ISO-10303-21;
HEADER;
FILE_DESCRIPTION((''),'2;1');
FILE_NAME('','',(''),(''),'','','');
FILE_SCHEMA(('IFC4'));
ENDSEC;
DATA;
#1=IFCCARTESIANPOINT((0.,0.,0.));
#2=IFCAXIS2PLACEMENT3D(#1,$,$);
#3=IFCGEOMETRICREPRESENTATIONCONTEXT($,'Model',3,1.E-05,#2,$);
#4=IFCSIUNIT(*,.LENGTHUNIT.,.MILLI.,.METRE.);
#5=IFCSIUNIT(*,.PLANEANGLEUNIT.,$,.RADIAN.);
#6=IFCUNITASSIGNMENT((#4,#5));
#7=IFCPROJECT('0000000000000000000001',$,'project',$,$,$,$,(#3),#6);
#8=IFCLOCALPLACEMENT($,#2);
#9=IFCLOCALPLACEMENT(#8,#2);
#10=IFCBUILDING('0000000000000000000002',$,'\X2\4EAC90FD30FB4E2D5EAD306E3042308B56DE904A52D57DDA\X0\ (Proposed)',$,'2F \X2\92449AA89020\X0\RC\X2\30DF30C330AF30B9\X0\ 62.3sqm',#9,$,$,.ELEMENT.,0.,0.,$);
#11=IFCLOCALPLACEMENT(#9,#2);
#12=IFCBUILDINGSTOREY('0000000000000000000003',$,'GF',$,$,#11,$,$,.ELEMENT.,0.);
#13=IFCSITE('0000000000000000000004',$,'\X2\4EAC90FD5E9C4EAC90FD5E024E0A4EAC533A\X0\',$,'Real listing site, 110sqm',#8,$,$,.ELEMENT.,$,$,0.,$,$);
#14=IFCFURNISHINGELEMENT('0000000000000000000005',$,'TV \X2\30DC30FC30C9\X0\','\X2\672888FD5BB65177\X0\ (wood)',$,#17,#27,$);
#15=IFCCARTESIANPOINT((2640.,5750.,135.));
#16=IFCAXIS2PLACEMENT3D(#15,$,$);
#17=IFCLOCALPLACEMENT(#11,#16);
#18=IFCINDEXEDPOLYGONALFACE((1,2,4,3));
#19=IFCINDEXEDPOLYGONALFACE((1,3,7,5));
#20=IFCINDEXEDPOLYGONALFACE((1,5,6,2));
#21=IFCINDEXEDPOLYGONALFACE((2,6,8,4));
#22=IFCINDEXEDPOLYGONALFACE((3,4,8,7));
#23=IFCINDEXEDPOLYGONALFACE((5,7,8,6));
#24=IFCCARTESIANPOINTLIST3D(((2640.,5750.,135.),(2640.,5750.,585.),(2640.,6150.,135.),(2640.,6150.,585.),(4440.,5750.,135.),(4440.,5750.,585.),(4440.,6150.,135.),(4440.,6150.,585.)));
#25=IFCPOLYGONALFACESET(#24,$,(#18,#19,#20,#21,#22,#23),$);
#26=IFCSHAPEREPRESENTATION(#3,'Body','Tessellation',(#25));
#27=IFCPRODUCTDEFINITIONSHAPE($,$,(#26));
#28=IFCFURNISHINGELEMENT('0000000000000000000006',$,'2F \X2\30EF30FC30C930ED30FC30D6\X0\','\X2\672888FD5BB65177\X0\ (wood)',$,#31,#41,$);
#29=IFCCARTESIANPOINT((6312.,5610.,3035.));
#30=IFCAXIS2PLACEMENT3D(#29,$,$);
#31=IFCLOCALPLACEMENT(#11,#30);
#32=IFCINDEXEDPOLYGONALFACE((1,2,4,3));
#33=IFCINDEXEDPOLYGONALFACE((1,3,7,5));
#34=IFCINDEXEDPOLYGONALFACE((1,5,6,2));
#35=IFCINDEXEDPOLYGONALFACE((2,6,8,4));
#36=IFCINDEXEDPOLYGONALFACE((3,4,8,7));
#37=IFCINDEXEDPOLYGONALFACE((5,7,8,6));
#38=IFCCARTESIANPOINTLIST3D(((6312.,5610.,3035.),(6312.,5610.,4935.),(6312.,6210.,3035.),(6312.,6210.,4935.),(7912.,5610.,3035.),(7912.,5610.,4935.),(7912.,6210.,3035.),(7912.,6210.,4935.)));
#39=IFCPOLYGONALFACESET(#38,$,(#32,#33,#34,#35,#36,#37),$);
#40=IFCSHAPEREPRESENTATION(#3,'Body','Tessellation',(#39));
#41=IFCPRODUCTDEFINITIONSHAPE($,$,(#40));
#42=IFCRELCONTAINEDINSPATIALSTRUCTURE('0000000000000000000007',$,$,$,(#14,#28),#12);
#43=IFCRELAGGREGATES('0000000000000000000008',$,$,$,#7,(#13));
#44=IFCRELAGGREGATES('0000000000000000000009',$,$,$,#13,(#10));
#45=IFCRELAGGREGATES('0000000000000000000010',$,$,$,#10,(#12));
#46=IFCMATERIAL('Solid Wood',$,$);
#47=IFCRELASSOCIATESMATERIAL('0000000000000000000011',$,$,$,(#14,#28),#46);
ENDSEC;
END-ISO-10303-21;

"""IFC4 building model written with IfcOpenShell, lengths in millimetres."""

from ifc_helpers import new_model, si_unit, frame, frame_2d, origin, place, context, project, spatial, rectangle, extrude, material, element, save


model = new_model("IFC4")

# Units and contexts
model_context = context("Model", 3, precision=1e-05, world=origin())
ifc_project = project(units=[si_unit("LENGTHUNIT", "METRE", prefix="MILLI"), si_unit("PLANEANGLEUNIT", "RADIAN")], contexts=[model_context])

# Site, building, storey
site_placement = place(None, origin())
site = spatial("IfcSite", under=ifc_project, at=site_placement, Name="京都府京都市上京区", ObjectType="Real listing site, 110sqm", CompositionType="ELEMENT", RefElevation=0.0)
building_placement = place(site_placement, origin())
building = spatial("IfcBuilding", under=site, at=building_placement, Name="京都・中庭のある回遊動線 (Proposed)", ObjectType="2F 鉄骨造RCミックス 62.3sqm", CompositionType="ELEMENT", ElevationOfRefHeight=0.0, ElevationOfTerrain=0.0)
storey_placement = place(building_placement, origin())
storey = spatial("IfcBuildingStorey", under=building, at=storey_placement, Name="GF", CompositionType="ELEMENT", Elevation=0.0)

# Shared definitions
ifc_material_1 = material(Name="Solid Wood")

# Furnishing elements
furnishing_1_placement = place(storey_placement, frame((2640.0, 5750.0, 135.0)))
element("IfcFurnishingElement", 1, at=furnishing_1_placement, inside=storey, material=ifc_material_1, Name="TV ボード", Description="木製家具 (wood)", context=model_context, shape_type="SweptSolid", body=[
    extrude(rectangle(XDim=1800.0, YDim=400.0, at=frame_2d((900.0, 200.0))), frame((2640.0, 5750.0, 135.0)), (0.0, 0.0, 1.0), 450.0),
])
furnishing_2_placement = place(storey_placement, frame((6312.0, 5610.0, 3035.0)))
element("IfcFurnishingElement", 2, at=furnishing_2_placement, inside=storey, material=ifc_material_1, Name="2F ワードローブ", Description="木製家具 (wood)", context=model_context, shape_type="SweptSolid", body=[
    extrude(rectangle(XDim=1600.0, YDim=600.0, at=frame_2d((800.0, 300.0))), frame((6312.0, 5610.0, 3035.0)), (0.0, 0.0, 1.0), 1900.0),
])

save(model, "model.ifc")
